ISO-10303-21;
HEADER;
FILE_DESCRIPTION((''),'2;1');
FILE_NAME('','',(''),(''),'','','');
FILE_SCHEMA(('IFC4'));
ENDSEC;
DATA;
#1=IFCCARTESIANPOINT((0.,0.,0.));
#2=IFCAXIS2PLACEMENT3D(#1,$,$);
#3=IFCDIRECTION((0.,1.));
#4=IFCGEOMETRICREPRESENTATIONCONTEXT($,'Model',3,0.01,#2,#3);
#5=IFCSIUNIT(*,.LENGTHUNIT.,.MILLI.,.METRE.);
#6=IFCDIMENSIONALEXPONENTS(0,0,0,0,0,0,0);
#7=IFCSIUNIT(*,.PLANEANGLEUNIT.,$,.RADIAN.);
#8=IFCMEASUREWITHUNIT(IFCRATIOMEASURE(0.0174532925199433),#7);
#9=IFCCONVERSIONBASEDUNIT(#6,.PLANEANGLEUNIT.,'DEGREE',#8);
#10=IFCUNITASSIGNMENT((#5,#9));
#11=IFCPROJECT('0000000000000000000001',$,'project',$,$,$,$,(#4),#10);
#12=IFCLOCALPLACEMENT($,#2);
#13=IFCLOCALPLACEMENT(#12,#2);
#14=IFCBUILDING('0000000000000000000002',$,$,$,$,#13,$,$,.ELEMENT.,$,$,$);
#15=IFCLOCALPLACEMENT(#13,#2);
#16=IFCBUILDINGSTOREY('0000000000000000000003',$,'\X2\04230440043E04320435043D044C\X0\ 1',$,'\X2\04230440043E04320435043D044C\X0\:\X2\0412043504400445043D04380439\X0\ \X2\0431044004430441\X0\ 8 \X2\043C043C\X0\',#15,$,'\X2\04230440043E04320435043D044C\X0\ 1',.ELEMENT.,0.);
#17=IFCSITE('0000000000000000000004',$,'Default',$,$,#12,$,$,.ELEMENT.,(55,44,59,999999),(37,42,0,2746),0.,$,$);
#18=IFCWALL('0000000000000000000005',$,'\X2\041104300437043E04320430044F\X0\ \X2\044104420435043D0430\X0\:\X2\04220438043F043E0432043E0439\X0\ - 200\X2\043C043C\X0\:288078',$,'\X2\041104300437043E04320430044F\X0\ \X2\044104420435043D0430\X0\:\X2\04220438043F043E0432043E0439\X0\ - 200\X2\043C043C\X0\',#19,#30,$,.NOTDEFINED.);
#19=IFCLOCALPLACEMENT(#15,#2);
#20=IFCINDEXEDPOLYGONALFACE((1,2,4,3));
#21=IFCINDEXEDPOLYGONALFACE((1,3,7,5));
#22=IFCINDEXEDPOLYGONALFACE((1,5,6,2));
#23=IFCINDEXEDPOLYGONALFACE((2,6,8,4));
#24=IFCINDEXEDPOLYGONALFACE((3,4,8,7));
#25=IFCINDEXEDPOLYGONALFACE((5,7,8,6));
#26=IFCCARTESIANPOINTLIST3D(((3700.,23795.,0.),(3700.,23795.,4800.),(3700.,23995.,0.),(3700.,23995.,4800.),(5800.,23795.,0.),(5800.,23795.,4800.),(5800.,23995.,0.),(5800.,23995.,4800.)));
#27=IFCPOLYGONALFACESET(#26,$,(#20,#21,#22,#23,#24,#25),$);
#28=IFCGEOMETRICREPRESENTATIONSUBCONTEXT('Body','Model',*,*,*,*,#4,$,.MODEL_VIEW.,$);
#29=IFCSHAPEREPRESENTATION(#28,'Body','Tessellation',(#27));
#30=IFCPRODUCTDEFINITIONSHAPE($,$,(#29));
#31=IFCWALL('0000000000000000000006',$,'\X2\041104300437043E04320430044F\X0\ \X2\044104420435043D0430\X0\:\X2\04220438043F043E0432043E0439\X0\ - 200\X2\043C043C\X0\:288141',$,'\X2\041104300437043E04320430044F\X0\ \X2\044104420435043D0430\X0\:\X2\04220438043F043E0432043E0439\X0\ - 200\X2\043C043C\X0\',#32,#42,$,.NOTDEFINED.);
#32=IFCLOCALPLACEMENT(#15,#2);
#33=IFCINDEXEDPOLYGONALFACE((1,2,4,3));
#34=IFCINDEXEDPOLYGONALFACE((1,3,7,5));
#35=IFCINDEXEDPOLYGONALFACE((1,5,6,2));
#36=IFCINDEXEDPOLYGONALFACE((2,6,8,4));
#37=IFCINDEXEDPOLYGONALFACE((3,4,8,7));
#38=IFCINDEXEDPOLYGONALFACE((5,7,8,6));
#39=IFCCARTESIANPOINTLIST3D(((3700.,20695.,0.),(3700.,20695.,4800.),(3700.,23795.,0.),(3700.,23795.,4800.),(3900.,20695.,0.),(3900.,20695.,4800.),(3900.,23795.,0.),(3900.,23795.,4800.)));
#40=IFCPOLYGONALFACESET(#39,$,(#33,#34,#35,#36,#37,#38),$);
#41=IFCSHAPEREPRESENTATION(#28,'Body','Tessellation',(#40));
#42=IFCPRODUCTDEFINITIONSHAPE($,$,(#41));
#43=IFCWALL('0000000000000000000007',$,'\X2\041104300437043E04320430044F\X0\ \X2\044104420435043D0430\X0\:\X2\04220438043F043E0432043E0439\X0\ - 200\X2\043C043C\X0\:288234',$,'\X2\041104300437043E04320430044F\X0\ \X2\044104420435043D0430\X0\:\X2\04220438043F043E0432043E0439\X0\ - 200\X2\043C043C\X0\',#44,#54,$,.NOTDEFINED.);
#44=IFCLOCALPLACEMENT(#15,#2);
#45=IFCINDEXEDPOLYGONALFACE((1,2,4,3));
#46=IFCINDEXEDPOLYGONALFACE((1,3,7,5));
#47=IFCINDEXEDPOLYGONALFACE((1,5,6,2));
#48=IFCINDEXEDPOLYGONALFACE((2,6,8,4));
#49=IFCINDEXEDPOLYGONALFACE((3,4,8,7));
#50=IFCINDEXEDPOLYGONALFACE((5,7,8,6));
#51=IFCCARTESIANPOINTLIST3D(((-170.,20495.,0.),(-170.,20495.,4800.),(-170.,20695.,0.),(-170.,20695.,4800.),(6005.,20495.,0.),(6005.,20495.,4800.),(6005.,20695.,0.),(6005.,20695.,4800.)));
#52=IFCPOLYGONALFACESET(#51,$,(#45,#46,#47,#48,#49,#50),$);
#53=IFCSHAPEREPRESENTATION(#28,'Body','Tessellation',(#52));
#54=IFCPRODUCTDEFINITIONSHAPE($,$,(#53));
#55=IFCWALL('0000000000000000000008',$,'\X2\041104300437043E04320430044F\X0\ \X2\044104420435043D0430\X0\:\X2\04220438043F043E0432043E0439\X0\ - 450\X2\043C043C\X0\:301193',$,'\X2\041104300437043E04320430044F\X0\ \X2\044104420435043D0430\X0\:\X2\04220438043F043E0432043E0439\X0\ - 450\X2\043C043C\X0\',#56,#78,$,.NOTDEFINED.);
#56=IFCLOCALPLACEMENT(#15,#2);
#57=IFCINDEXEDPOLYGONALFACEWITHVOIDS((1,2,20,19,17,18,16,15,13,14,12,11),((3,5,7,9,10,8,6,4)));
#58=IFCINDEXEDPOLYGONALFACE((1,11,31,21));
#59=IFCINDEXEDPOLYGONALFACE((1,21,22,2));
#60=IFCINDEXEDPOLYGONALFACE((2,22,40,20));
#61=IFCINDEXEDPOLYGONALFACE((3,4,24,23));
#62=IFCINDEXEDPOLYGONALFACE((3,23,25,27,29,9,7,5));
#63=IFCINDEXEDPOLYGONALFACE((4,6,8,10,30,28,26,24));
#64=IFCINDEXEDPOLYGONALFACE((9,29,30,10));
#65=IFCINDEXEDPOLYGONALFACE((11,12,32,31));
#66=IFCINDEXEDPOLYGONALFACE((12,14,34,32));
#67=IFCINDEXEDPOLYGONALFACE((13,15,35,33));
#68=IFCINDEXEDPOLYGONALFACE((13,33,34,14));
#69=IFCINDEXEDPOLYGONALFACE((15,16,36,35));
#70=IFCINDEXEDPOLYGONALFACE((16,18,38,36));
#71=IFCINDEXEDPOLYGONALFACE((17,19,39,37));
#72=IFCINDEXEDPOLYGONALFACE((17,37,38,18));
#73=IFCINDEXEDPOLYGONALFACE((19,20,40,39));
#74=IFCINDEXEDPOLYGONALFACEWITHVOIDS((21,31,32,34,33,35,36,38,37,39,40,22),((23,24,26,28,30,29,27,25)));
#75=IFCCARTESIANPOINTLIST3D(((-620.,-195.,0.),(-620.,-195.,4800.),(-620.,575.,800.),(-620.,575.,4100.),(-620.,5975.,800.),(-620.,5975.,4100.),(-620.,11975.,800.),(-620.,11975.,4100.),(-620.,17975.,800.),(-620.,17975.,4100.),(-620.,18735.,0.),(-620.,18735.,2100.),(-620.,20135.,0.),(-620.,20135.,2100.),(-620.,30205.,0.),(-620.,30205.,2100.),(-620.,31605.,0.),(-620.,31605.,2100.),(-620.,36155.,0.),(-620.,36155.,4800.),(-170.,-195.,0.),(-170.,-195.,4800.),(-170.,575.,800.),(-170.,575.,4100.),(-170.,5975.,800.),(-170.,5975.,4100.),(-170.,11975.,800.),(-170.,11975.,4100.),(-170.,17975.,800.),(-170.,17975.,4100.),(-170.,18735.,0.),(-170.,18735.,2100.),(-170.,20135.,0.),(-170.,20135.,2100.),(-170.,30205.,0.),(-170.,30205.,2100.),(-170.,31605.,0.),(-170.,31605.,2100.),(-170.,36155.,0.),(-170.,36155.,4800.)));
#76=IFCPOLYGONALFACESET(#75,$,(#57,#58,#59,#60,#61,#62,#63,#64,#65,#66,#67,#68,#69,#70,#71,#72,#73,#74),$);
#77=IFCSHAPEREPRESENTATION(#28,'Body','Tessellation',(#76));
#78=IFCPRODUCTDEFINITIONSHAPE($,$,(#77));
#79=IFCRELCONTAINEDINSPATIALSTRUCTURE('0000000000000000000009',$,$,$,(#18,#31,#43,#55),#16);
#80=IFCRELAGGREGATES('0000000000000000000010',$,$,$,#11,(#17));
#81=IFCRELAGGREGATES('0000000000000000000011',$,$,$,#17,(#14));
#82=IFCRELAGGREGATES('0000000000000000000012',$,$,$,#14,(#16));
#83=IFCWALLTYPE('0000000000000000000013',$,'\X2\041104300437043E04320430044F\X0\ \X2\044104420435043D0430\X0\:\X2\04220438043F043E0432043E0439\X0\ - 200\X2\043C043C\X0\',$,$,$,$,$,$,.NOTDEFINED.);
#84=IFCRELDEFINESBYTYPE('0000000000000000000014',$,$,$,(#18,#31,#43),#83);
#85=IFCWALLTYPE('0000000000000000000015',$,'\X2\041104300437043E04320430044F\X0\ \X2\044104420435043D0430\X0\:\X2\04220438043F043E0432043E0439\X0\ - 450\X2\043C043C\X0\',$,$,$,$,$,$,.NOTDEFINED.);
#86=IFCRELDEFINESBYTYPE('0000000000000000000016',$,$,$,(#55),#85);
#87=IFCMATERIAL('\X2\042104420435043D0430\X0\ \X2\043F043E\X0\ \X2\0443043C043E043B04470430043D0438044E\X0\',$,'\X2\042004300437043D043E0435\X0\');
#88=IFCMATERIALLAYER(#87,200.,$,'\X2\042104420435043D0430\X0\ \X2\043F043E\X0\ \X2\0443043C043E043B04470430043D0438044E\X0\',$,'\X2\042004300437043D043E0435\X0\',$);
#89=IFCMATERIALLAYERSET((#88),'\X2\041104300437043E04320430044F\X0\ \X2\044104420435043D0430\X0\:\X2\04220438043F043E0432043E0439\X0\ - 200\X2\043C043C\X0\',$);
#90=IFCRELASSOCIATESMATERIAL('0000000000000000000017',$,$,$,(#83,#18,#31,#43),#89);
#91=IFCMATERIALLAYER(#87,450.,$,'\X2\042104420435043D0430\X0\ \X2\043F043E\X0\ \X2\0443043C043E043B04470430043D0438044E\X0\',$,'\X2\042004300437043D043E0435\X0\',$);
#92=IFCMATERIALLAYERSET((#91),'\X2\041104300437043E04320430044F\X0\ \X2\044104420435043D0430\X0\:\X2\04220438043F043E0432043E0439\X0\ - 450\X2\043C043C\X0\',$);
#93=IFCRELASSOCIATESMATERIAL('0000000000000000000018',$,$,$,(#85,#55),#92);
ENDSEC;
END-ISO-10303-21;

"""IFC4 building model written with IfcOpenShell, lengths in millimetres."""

from ifc_helpers import new_model, entity, si_unit, converted_unit, direction, frame, frame_2d, origin, place, context, subcontext, project, spatial, rectangle, extrude, material, layer, layer_set, layer_usage, type_object, element, save


model = new_model("IFC4")

# Units and contexts
model_context = context("Model", 3, precision=0.01, world=origin(), true_north=direction((0.0, 1.0)))
body_context = subcontext(model_context, "Body", "Model", "MODEL_VIEW")
ifc_project = project(units=[si_unit("LENGTHUNIT", "METRE", prefix="MILLI"), converted_unit("PLANEANGLEUNIT", "DEGREE", entity("IfcRatioMeasure", 0.0174532925199433), si_unit("PLANEANGLEUNIT", "RADIAN"), dimensions=[0, 0, 0, 0, 0, 0, 0])], contexts=[model_context])

# Site, building, storey
site_placement = place(None, origin())
site = spatial("IfcSite", under=ifc_project, at=site_placement, Name="Default", CompositionType="ELEMENT", RefLatitude=(55, 44, 59, 999999), RefLongitude=(37, 42, 0, 2746), RefElevation=0.0)
building_placement = place(site_placement, origin())
building = spatial("IfcBuilding", under=site, at=building_placement, CompositionType="ELEMENT")
storey_placement = place(building_placement, origin())
storey = spatial("IfcBuildingStorey", under=building, at=storey_placement, Name="Уровень 1", ObjectType="Уровень:Верхний брус 8 мм", LongName="Уровень 1", CompositionType="ELEMENT", Elevation=0.0)

# Shared definitions
ifc_material_1 = material(Name="Стена по умолчанию", Category="Разное")
ifc_layer_1 = layer(ifc_material_1, 200.0, Name="Стена по умолчанию", Category="Разное")
ifc_layer_set_1 = layer_set([ifc_layer_1], Name="Базовая стена:Типовой - 200мм")
wall_type_1 = type_object("IfcWallType", Name="Базовая стена:Типовой - 200мм", PredefinedType="NOTDEFINED", material=ifc_layer_set_1)

# Walls
ifc_layer_usage_1 = layer_usage(ifc_layer_set_1, "AXIS2", "NEGATIVE", 100.0)
wall_1_placement = place(storey_placement, frame((3700.0, 23895.0, 0.0)))
element("IfcWall", 1, at=wall_1_placement, inside=storey, type_object=wall_type_1, material=ifc_layer_usage_1, Name="Базовая стена:Типовой - 200мм:288078", ObjectType="Базовая стена:Типовой - 200мм", PredefinedType="NOTDEFINED", context=body_context, shape_type="SweptSolid", body=[
    extrude(rectangle(XDim=2100.0, YDim=200.0, at=frame_2d((1050.0, 0.0), x_axis=(-1.0, 0.0))), origin(), (0.0, 0.0, 1.0), 4800.0),
])
ifc_layer_usage_2 = layer_usage(ifc_layer_set_1, "AXIS2", "NEGATIVE", 100.0)
wall_2_placement = place(storey_placement, frame((3800.0, 23795.0, 0.0), z_axis=(0.0, 0.0, 1.0), x_axis=(0.0, -1.0, 0.0)))
element("IfcWall", 2, at=wall_2_placement, inside=storey, type_object=wall_type_1, material=ifc_layer_usage_2, Name="Базовая стена:Типовой - 200мм:288141", ObjectType="Базовая стена:Типовой - 200мм", PredefinedType="NOTDEFINED", context=body_context, shape_type="SweptSolid", body=[
    extrude(rectangle(XDim=3100.0, YDim=200.0, at=frame_2d((1550.0, 0.0), x_axis=(-1.0, 0.0))), origin(), (0.0, 0.0, 1.0), 4800.0),
])
ifc_layer_usage_3 = layer_usage(ifc_layer_set_1, "AXIS2", "NEGATIVE", 100.0)
wall_3_placement = place(storey_placement, frame((-170.0, 20595.0, 0.0)))
element("IfcWall", 3, at=wall_3_placement, inside=storey, type_object=wall_type_1, material=ifc_layer_usage_3, Name="Базовая стена:Типовой - 200мм:288234", ObjectType="Базовая стена:Типовой - 200мм", PredefinedType="NOTDEFINED", context=body_context, shape_type="SweptSolid", body=[
    extrude(rectangle(XDim=6175.0, YDim=200.0, at=frame_2d((3087.5, 0.0), x_axis=(-1.0, 0.0))), origin(), (0.0, 0.0, 1.0), 4800.0),
])

# Wall, openings
ifc_layer_2 = layer(ifc_material_1, 450.0, Name="Стена по умолчанию", Category="Разное")
ifc_layer_set_2 = layer_set([ifc_layer_2], Name="Базовая стена:Типовой - 450мм")
ifc_layer_usage_4 = layer_usage(ifc_layer_set_2, "AXIS2", "NEGATIVE", 225.0)
wall_type_2 = type_object("IfcWallType", Name="Базовая стена:Типовой - 450мм", PredefinedType="NOTDEFINED", material=ifc_layer_set_2)
wall_4_placement = place(storey_placement, frame((-395.0, 36155.0, 0.0), z_axis=(0.0, 0.0, 1.0), x_axis=(0.0, -1.0, 0.0)))
wall_4 = element("IfcWall", 4, at=wall_4_placement, inside=storey, type_object=wall_type_2, material=ifc_layer_usage_4, Name="Базовая стена:Типовой - 450мм:301193", ObjectType="Базовая стена:Типовой - 450мм", PredefinedType="NOTDEFINED", context=body_context, shape_type="SweptSolid", body=[
    extrude(rectangle(XDim=36350.0, YDim=450.0, at=frame_2d((18175.0, 0.0), x_axis=(-1.0, 0.0))), origin(), (0.0, 0.0, 1.0), 4800.0),
])
opening_1_placement = place(wall_4_placement, frame((35580.0, -377.4, 800.0)))
element("IfcOpeningElement", 5, at=opening_1_placement, cuts=wall_4, ObjectType="Opening", PredefinedType="OPENING", context=body_context, shape_type="SweptSolid", body=[
    extrude(rectangle(XDim=3300.0, YDim=5400.0, at=frame_2d((0.0, 0.0), x_axis=(0.0, 1.0))), frame((-2700.0, 0.0, 1650.0), z_axis=(0.0, 1.0, 0.0), x_axis=(-1.0, 0.0, 0.0)), (0.0, 0.0, 1.0), 754.8),
])
opening_2_placement = place(wall_4_placement, frame((30180.0, -377.4, 800.0)))
element("IfcOpeningElement", 6, at=opening_2_placement, cuts=wall_4, ObjectType="Opening", PredefinedType="OPENING", context=body_context, shape_type="SweptSolid", body=[
    extrude(rectangle(XDim=3300.0, YDim=6000.0, at=frame_2d((0.0, 0.0), x_axis=(0.0, 1.0))), frame((-3000.0, 0.0, 1650.0), z_axis=(0.0, 1.0, 0.0), x_axis=(-1.0, 0.0, 0.0)), (0.0, 0.0, 1.0), 754.8),
])
opening_3_placement = place(wall_4_placement, frame((24180.0, -377.4, 800.0)))
element("IfcOpeningElement", 7, at=opening_3_placement, cuts=wall_4, ObjectType="Opening", PredefinedType="OPENING", context=body_context, shape_type="SweptSolid", body=[
    extrude(rectangle(XDim=3300.0, YDim=6000.0, at=frame_2d((0.0, 0.0), x_axis=(0.0, 1.0))), frame((-3000.0, 0.0, 1650.0), z_axis=(0.0, 1.0, 0.0), x_axis=(-1.0, 0.0, 0.0)), (0.0, 0.0, 1.0), 754.8),
])
opening_4_placement = place(wall_4_placement, frame((17420.0, -725.0, 0.0), z_axis=(0.0, 0.0, 1.0), x_axis=(0.0, 1.0, 0.0)))
element("IfcOpeningElement", 8, at=opening_4_placement, cuts=wall_4, ObjectType="Opening", PredefinedType="OPENING", context=body_context, shape_type="SweptSolid", body=[
    extrude(rectangle(XDim=2100.0, YDim=1400.0, at=frame_2d((0.0, 0.0), x_axis=(0.0, 1.0))), frame((0.0, 700.0, 1050.0), z_axis=(1.0, 0.0, 0.0), x_axis=(0.0, -1.0, 0.0)), (0.0, 0.0, 1.0), 1450.0),
])
opening_5_placement = place(wall_4_placement, frame((5950.0, -725.0, 0.0), z_axis=(0.0, 0.0, 1.0), x_axis=(0.0, 1.0, 0.0)))
element("IfcOpeningElement", 9, at=opening_5_placement, cuts=wall_4, ObjectType="Opening", PredefinedType="OPENING", context=body_context, shape_type="SweptSolid", body=[
    extrude(rectangle(XDim=2100.0, YDim=1400.0, at=frame_2d((0.0, 0.0), x_axis=(0.0, 1.0))), frame((0.0, 700.0, 1050.0), z_axis=(1.0, 0.0, 0.0), x_axis=(0.0, -1.0, 0.0)), (0.0, 0.0, 1.0), 1450.0),
])

save(model, "model.ifc")
